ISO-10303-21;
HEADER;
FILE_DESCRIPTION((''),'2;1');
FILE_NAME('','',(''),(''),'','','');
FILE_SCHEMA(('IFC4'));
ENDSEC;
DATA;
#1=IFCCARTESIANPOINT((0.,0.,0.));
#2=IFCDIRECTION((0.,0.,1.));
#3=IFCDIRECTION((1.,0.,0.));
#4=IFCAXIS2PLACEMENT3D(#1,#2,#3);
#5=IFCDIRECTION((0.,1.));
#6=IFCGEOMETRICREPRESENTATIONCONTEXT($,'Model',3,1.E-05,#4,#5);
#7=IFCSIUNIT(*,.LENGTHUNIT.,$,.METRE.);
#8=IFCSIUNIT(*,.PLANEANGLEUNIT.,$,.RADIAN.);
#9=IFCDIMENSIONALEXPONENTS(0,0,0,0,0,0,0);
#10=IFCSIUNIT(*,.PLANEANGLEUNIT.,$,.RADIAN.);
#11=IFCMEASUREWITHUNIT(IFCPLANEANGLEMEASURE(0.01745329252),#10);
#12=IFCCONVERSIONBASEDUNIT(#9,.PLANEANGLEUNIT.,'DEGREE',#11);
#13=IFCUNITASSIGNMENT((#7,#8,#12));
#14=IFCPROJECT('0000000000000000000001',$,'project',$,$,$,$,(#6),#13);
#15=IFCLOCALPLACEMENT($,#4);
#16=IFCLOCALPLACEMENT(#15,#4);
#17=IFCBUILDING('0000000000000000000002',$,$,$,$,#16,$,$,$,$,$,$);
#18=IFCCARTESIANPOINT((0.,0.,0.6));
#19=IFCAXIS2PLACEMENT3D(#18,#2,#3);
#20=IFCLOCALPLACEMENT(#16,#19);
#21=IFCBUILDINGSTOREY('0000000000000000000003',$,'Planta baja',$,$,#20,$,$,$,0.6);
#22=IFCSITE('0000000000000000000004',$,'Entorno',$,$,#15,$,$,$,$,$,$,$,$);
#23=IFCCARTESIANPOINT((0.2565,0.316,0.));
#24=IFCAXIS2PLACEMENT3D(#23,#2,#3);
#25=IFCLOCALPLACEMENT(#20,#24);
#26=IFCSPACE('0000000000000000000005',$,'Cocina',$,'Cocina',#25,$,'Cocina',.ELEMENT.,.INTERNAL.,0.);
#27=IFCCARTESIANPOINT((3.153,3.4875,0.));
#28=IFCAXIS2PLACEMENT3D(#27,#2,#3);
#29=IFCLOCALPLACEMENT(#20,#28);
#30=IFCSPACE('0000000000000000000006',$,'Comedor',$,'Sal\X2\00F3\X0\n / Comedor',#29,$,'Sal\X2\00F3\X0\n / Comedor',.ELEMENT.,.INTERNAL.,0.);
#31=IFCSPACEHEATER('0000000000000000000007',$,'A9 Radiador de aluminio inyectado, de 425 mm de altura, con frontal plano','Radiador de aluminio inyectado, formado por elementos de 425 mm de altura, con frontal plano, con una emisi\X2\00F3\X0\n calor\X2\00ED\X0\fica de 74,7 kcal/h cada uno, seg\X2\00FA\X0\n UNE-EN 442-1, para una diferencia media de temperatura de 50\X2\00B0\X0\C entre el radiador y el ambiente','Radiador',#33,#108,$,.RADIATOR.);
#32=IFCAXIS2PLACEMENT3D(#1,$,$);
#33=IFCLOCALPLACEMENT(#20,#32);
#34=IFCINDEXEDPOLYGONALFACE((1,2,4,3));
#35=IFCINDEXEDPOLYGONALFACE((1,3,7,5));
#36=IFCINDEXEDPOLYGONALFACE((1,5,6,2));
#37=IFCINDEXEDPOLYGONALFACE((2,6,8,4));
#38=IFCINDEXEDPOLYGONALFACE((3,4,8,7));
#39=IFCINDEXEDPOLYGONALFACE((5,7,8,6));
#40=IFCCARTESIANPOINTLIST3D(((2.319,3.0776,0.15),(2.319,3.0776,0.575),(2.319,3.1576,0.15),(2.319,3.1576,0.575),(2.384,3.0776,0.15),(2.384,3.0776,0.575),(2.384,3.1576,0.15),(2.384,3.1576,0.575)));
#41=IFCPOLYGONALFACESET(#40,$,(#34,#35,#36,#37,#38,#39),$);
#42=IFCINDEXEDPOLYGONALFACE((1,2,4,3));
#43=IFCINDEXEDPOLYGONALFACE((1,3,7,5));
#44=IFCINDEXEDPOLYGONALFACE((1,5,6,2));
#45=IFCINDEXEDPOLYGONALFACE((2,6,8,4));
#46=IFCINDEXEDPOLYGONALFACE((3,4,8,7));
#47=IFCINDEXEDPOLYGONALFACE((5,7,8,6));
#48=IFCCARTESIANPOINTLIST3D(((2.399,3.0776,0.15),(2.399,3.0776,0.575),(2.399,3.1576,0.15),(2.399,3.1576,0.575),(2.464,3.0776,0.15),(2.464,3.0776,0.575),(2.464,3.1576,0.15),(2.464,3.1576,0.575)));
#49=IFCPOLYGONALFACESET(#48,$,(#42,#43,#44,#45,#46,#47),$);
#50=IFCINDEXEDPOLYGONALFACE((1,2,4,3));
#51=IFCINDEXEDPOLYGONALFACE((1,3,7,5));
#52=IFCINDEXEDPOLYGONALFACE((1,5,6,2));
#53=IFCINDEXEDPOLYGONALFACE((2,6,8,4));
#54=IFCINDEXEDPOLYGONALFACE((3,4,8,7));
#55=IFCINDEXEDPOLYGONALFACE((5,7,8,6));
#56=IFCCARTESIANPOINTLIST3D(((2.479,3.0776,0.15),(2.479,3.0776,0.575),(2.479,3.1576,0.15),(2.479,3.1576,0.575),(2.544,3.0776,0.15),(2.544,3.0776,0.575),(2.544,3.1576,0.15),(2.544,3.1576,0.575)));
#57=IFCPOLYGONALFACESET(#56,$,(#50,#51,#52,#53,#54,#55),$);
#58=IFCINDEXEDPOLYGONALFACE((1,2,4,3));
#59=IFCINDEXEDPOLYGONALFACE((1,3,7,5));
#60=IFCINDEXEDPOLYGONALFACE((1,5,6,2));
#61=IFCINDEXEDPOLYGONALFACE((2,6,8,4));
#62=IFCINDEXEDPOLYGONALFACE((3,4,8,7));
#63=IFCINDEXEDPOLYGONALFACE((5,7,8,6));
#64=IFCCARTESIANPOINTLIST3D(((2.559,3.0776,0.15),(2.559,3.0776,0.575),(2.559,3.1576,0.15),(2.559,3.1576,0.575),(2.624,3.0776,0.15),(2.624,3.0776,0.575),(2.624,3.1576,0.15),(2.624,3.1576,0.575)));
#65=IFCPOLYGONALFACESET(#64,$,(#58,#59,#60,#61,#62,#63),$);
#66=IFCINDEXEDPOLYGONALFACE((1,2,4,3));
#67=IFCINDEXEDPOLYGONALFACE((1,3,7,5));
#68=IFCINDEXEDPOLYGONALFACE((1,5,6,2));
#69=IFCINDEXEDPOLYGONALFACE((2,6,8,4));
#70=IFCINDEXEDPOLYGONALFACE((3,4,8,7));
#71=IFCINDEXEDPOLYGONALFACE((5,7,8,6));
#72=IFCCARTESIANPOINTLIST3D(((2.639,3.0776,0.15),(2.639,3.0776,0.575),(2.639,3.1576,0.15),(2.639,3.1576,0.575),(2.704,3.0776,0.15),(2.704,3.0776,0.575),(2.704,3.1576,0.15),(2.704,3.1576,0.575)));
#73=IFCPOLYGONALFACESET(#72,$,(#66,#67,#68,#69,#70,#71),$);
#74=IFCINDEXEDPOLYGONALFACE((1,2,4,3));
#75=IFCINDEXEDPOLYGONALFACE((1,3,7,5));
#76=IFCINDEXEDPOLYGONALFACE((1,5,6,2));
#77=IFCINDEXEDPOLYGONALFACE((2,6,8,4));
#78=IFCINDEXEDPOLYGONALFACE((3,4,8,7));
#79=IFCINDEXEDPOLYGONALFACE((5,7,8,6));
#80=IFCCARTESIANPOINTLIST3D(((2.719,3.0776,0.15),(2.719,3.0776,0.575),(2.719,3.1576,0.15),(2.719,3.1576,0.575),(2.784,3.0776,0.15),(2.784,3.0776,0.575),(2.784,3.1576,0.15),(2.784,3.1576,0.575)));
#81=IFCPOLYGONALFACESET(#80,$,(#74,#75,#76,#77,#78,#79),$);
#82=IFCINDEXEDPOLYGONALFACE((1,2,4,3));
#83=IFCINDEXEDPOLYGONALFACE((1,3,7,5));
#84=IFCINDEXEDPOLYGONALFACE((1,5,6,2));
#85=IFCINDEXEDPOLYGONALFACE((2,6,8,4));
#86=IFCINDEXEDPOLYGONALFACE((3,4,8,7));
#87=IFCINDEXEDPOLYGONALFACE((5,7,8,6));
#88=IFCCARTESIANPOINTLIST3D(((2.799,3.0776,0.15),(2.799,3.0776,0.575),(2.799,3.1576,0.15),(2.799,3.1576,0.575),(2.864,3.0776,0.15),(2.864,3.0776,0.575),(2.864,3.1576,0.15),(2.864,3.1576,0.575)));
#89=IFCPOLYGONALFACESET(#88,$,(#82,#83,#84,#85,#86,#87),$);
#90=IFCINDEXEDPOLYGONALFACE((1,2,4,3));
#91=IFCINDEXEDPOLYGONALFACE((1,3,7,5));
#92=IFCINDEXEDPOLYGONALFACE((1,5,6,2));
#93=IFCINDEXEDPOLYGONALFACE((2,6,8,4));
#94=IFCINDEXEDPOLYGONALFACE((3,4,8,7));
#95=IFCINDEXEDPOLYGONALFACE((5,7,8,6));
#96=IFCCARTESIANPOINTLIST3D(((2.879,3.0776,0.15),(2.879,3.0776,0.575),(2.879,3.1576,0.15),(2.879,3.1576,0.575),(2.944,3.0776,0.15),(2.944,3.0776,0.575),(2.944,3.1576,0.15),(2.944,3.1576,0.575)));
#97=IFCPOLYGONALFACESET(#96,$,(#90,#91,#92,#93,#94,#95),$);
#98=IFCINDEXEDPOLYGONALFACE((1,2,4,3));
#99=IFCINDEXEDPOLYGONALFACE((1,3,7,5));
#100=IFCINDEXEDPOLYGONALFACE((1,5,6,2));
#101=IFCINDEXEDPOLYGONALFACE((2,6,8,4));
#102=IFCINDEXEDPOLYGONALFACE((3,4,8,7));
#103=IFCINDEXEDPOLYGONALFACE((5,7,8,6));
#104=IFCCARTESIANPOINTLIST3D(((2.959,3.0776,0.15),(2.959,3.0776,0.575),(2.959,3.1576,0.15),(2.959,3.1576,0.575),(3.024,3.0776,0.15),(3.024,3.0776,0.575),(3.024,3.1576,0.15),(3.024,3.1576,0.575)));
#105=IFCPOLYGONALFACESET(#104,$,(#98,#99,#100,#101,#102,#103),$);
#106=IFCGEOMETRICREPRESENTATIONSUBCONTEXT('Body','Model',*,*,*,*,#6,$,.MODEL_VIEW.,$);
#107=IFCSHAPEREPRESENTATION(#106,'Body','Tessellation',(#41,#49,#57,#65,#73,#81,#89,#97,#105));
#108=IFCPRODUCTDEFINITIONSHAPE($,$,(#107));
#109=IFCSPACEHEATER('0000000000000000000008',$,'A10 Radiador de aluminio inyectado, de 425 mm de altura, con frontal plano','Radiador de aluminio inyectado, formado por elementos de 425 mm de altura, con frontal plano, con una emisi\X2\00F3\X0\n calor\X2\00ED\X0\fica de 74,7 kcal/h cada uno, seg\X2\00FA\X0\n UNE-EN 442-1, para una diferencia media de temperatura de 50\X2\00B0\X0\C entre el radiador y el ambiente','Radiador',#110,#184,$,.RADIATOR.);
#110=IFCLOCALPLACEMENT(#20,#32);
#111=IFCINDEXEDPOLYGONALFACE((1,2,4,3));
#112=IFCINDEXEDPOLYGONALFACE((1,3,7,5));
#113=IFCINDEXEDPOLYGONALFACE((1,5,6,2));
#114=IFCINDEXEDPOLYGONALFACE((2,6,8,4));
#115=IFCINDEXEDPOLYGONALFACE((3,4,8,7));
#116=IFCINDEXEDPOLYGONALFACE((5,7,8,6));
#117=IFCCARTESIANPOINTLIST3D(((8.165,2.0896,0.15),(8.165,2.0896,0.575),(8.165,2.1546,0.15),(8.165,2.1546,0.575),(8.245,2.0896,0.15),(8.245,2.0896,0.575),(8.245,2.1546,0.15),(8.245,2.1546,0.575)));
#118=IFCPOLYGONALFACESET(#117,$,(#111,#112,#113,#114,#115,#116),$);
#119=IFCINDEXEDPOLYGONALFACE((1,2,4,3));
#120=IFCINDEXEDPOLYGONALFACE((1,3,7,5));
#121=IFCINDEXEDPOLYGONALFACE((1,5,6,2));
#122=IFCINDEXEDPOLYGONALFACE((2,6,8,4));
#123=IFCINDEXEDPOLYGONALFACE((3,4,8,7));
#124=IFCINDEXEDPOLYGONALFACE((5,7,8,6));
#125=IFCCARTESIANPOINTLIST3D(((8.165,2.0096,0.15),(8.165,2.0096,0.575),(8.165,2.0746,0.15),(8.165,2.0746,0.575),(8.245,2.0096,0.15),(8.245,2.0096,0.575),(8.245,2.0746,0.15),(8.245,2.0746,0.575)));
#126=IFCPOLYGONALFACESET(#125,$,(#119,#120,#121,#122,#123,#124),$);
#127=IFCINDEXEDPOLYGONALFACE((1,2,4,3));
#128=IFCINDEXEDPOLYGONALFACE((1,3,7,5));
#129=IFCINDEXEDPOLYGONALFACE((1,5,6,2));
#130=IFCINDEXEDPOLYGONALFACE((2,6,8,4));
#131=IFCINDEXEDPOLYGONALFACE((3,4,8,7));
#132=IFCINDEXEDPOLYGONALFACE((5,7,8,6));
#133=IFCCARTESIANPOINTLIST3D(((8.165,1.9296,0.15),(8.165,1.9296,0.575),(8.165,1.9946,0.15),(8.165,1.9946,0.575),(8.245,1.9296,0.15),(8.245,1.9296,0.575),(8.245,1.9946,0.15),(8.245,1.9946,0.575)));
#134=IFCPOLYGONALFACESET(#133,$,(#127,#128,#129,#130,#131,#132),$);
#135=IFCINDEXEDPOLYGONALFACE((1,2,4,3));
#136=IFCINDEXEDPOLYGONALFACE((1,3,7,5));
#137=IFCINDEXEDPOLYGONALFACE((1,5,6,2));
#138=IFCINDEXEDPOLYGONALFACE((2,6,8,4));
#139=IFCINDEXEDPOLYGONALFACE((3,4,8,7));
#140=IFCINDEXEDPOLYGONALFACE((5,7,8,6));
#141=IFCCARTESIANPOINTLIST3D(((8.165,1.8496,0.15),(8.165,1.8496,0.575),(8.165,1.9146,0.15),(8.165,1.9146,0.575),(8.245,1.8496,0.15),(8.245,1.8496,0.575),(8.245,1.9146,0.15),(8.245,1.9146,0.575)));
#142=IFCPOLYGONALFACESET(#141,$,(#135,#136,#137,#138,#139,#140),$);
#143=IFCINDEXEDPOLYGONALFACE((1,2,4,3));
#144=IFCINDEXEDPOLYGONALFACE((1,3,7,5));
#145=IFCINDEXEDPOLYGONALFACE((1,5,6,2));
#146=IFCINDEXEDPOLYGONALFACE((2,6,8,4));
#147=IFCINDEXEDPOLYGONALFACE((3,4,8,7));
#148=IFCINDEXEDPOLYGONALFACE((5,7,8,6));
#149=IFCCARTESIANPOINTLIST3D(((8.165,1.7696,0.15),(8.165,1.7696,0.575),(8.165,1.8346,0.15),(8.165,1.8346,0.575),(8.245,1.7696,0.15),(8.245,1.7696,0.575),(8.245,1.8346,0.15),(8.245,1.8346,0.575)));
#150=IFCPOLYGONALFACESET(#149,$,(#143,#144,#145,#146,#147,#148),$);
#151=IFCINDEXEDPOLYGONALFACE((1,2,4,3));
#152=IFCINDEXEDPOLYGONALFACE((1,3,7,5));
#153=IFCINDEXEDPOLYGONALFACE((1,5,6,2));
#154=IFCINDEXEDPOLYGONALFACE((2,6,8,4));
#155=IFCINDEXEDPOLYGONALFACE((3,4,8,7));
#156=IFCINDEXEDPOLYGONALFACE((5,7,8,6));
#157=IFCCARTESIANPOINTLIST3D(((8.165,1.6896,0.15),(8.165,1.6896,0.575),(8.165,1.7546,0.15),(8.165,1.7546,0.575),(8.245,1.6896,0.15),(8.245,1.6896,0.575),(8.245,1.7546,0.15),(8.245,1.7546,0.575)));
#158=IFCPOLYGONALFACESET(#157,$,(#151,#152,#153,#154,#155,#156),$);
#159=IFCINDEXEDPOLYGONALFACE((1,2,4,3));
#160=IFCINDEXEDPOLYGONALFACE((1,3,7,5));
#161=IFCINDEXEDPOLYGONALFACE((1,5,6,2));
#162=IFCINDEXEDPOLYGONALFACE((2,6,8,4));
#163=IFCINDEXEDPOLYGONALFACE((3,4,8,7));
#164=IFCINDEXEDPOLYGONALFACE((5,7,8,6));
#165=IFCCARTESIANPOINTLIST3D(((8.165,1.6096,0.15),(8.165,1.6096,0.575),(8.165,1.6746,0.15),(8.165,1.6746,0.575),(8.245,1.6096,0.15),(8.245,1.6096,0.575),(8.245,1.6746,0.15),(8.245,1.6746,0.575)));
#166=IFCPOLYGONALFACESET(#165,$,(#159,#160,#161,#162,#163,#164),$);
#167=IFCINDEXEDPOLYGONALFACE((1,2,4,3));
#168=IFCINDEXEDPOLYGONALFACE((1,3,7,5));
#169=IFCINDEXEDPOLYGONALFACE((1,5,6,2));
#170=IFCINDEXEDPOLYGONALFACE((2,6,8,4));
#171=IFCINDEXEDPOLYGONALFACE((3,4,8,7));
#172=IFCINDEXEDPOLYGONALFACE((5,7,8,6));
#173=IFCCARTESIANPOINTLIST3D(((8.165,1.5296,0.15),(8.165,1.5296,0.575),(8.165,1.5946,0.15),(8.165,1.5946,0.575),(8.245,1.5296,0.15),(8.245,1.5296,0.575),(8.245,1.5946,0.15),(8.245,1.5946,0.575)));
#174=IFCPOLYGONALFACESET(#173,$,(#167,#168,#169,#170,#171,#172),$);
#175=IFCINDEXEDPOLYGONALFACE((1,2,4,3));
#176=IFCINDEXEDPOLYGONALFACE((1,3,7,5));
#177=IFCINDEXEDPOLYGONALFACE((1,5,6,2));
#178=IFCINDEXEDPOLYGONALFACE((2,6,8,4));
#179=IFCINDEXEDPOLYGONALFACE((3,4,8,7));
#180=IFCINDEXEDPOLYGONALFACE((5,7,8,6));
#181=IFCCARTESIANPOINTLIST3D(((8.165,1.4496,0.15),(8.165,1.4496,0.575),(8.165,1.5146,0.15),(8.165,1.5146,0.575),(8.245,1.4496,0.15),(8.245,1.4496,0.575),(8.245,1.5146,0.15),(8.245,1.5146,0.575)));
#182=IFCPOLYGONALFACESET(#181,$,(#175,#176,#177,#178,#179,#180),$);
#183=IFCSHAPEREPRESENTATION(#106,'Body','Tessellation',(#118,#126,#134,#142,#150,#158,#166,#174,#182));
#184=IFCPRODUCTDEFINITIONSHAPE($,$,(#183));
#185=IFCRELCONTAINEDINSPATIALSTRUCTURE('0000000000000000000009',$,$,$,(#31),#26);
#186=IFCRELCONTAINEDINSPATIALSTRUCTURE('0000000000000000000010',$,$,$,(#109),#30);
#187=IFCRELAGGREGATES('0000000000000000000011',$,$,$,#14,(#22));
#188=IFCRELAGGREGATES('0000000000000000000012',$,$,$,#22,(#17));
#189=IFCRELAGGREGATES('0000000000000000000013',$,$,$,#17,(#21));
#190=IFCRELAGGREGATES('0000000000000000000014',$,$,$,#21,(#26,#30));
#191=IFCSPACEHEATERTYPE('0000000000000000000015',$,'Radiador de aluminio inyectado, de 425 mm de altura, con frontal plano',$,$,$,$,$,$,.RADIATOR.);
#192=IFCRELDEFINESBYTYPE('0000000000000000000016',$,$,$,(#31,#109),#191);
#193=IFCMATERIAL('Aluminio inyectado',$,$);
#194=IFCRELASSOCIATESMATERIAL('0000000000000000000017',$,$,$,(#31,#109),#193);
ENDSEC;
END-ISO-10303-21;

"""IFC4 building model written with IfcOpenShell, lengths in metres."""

from ifc_helpers import new_model, entity, si_unit, converted_unit, direction, frame, origin_with_axes, origin_2d_with_axis, place, context, subcontext, project, spatial, rectangle, extrude, material, type_object, element, save


model = new_model("IFC4")

# Units and contexts
model_context = context("Model", 3, precision=1e-05, world=origin_with_axes(), true_north=direction((0.0, 1.0)))
body_context = subcontext(model_context, "Body", "Model", "MODEL_VIEW")
ifc_project = project(units=[si_unit("LENGTHUNIT", "METRE"), si_unit("PLANEANGLEUNIT", "RADIAN"), converted_unit("PLANEANGLEUNIT", "DEGREE", entity("IfcPlaneAngleMeasure", 0.01745329252), si_unit("PLANEANGLEUNIT", "RADIAN"), dimensions=[0, 0, 0, 0, 0, 0, 0])], contexts=[model_context])

# Site, building, storey
site_placement = place(None, origin_with_axes())
site = spatial("IfcSite", under=ifc_project, at=site_placement, Name="Entorno")
building_placement = place(site_placement, origin_with_axes())
building = spatial("IfcBuilding", under=site, at=building_placement)
storey_placement = place(building_placement, frame((0.0, 0.0, 0.6), z_axis=(0.0, 0.0, 1.0), x_axis=(1.0, 0.0, 0.0)))
storey = spatial("IfcBuildingStorey", under=building, at=storey_placement, Name="Planta baja", Elevation=0.6)

# Shared definitions
space_1_placement = place(storey_placement, frame((0.2565, 0.316, 0.0), z_axis=(0.0, 0.0, 1.0), x_axis=(1.0, 0.0, 0.0)))
space_1 = spatial("IfcSpace", under=storey, at=space_1_placement, Name="Cocina", ObjectType="Cocina", LongName="Cocina", CompositionType="ELEMENT", PredefinedType="INTERNAL", ElevationWithFlooring=0.0)

# Space heater
ifc_material_1 = material(Name="Aluminio inyectado")
space_heater_type = type_object("IfcSpaceHeaterType", Name="Radiador de aluminio inyectado, de 425 mm de altura, con frontal plano", PredefinedType="RADIATOR")
space_heater_1_placement = place(space_1_placement, frame((2.415, 2.8016, 0.15), z_axis=(0.0, 0.0, 1.0), x_axis=(1.0, 0.0, 0.0)))
element("IfcSpaceHeater", 1, at=space_heater_1_placement, inside=space_1, type_object=space_heater_type, material=ifc_material_1, Name="A9 Radiador de aluminio inyectado, de 425 mm de altura, con frontal plano", Description="Radiador de aluminio inyectado, formado por elementos de 425 mm de altura, con frontal plano, con una emisión calorífica de 74,7 kcal/h cada uno, según UNE-EN 442-1, para una diferencia media de temperatura de 50°C entre el radiador y el ambiente", ObjectType="Radiador", PredefinedType="RADIATOR", context=body_context, shape_type="SweptSolid", body=[
    extrude(rectangle(XDim=0.065, YDim=0.08, at=origin_2d_with_axis()), frame((-0.32, 0.0, 0.0), z_axis=(0.0, 0.0, 1.0), x_axis=(1.0, 0.0, 0.0)), (0.0, 0.0, 1.0), 0.425),
    extrude(rectangle(XDim=0.065, YDim=0.08, at=origin_2d_with_axis()), frame((-0.24, 0.0, 0.0), z_axis=(0.0, 0.0, 1.0), x_axis=(1.0, 0.0, 0.0)), (0.0, 0.0, 1.0), 0.425),
    extrude(rectangle(XDim=0.065, YDim=0.08, at=origin_2d_with_axis()), frame((-0.16, 0.0, 0.0), z_axis=(0.0, 0.0, 1.0), x_axis=(1.0, 0.0, 0.0)), (0.0, 0.0, 1.0), 0.425),
    extrude(rectangle(XDim=0.065, YDim=0.08, at=origin_2d_with_axis()), frame((-0.08, 0.0, 0.0), z_axis=(0.0, 0.0, 1.0), x_axis=(1.0, 0.0, 0.0)), (0.0, 0.0, 1.0), 0.425),
    extrude(rectangle(XDim=0.065, YDim=0.08, at=origin_2d_with_axis()), origin_with_axes(), (0.0, 0.0, 1.0), 0.425),
    extrude(rectangle(XDim=0.065, YDim=0.08, at=origin_2d_with_axis()), frame((0.08, 0.0, 0.0), z_axis=(0.0, 0.0, 1.0), x_axis=(1.0, 0.0, 0.0)), (0.0, 0.0, 1.0), 0.425),
    extrude(rectangle(XDim=0.065, YDim=0.08, at=origin_2d_with_axis()), frame((0.16, 0.0, 0.0), z_axis=(0.0, 0.0, 1.0), x_axis=(1.0, 0.0, 0.0)), (0.0, 0.0, 1.0), 0.425),
    extrude(rectangle(XDim=0.065, YDim=0.08, at=origin_2d_with_axis()), frame((0.24, 0.0, 0.0), z_axis=(0.0, 0.0, 1.0), x_axis=(1.0, 0.0, 0.0)), (0.0, 0.0, 1.0), 0.425),
    extrude(rectangle(XDim=0.065, YDim=0.08, at=origin_2d_with_axis()), frame((0.32, 0.0, 0.0), z_axis=(0.0, 0.0, 1.0), x_axis=(1.0, 0.0, 0.0)), (0.0, 0.0, 1.0), 0.425),
])

# Shared definitions
space_2_placement = place(storey_placement, frame((3.153, 3.4875, 0.0), z_axis=(0.0, 0.0, 1.0), x_axis=(1.0, 0.0, 0.0)))
space_2 = spatial("IfcSpace", under=storey, at=space_2_placement, Name="Comedor", ObjectType="Salón / Comedor", LongName="Salón / Comedor", CompositionType="ELEMENT", PredefinedType="INTERNAL", ElevationWithFlooring=0.0)

# Space heater
space_heater_2_placement = place(space_2_placement, frame((5.052, -1.6854, 0.15), z_axis=(0.0, 0.0, 1.0), x_axis=(0.0, -1.0, 0.0)))
element("IfcSpaceHeater", 2, at=space_heater_2_placement, inside=space_2, type_object=space_heater_type, material=ifc_material_1, Name="A10 Radiador de aluminio inyectado, de 425 mm de altura, con frontal plano", Description="Radiador de aluminio inyectado, formado por elementos de 425 mm de altura, con frontal plano, con una emisión calorífica de 74,7 kcal/h cada uno, según UNE-EN 442-1, para una diferencia media de temperatura de 50°C entre el radiador y el ambiente", ObjectType="Radiador", PredefinedType="RADIATOR", context=body_context, shape_type="SweptSolid", body=[
    extrude(rectangle(XDim=0.065, YDim=0.08, at=origin_2d_with_axis()), frame((-0.32, 0.0, 0.0), z_axis=(0.0, 0.0, 1.0), x_axis=(1.0, 0.0, 0.0)), (0.0, 0.0, 1.0), 0.425),
    extrude(rectangle(XDim=0.065, YDim=0.08, at=origin_2d_with_axis()), frame((-0.24, 0.0, 0.0), z_axis=(0.0, 0.0, 1.0), x_axis=(1.0, 0.0, 0.0)), (0.0, 0.0, 1.0), 0.425),
    extrude(rectangle(XDim=0.065, YDim=0.08, at=origin_2d_with_axis()), frame((-0.16, 0.0, 0.0), z_axis=(0.0, 0.0, 1.0), x_axis=(1.0, 0.0, 0.0)), (0.0, 0.0, 1.0), 0.425),
    extrude(rectangle(XDim=0.065, YDim=0.08, at=origin_2d_with_axis()), frame((-0.08, 0.0, 0.0), z_axis=(0.0, 0.0, 1.0), x_axis=(1.0, 0.0, 0.0)), (0.0, 0.0, 1.0), 0.425),
    extrude(rectangle(XDim=0.065, YDim=0.08, at=origin_2d_with_axis()), origin_with_axes(), (0.0, 0.0, 1.0), 0.425),
    extrude(rectangle(XDim=0.065, YDim=0.08, at=origin_2d_with_axis()), frame((0.08, 0.0, 0.0), z_axis=(0.0, 0.0, 1.0), x_axis=(1.0, 0.0, 0.0)), (0.0, 0.0, 1.0), 0.425),
    extrude(rectangle(XDim=0.065, YDim=0.08, at=origin_2d_with_axis()), frame((0.16, 0.0, 0.0), z_axis=(0.0, 0.0, 1.0), x_axis=(1.0, 0.0, 0.0)), (0.0, 0.0, 1.0), 0.425),
    extrude(rectangle(XDim=0.065, YDim=0.08, at=origin_2d_with_axis()), frame((0.24, 0.0, 0.0), z_axis=(0.0, 0.0, 1.0), x_axis=(1.0, 0.0, 0.0)), (0.0, 0.0, 1.0), 0.425),
    extrude(rectangle(XDim=0.065, YDim=0.08, at=origin_2d_with_axis()), frame((0.32, 0.0, 0.0), z_axis=(0.0, 0.0, 1.0), x_axis=(1.0, 0.0, 0.0)), (0.0, 0.0, 1.0), 0.425),
])

save(model, "model.ifc")
